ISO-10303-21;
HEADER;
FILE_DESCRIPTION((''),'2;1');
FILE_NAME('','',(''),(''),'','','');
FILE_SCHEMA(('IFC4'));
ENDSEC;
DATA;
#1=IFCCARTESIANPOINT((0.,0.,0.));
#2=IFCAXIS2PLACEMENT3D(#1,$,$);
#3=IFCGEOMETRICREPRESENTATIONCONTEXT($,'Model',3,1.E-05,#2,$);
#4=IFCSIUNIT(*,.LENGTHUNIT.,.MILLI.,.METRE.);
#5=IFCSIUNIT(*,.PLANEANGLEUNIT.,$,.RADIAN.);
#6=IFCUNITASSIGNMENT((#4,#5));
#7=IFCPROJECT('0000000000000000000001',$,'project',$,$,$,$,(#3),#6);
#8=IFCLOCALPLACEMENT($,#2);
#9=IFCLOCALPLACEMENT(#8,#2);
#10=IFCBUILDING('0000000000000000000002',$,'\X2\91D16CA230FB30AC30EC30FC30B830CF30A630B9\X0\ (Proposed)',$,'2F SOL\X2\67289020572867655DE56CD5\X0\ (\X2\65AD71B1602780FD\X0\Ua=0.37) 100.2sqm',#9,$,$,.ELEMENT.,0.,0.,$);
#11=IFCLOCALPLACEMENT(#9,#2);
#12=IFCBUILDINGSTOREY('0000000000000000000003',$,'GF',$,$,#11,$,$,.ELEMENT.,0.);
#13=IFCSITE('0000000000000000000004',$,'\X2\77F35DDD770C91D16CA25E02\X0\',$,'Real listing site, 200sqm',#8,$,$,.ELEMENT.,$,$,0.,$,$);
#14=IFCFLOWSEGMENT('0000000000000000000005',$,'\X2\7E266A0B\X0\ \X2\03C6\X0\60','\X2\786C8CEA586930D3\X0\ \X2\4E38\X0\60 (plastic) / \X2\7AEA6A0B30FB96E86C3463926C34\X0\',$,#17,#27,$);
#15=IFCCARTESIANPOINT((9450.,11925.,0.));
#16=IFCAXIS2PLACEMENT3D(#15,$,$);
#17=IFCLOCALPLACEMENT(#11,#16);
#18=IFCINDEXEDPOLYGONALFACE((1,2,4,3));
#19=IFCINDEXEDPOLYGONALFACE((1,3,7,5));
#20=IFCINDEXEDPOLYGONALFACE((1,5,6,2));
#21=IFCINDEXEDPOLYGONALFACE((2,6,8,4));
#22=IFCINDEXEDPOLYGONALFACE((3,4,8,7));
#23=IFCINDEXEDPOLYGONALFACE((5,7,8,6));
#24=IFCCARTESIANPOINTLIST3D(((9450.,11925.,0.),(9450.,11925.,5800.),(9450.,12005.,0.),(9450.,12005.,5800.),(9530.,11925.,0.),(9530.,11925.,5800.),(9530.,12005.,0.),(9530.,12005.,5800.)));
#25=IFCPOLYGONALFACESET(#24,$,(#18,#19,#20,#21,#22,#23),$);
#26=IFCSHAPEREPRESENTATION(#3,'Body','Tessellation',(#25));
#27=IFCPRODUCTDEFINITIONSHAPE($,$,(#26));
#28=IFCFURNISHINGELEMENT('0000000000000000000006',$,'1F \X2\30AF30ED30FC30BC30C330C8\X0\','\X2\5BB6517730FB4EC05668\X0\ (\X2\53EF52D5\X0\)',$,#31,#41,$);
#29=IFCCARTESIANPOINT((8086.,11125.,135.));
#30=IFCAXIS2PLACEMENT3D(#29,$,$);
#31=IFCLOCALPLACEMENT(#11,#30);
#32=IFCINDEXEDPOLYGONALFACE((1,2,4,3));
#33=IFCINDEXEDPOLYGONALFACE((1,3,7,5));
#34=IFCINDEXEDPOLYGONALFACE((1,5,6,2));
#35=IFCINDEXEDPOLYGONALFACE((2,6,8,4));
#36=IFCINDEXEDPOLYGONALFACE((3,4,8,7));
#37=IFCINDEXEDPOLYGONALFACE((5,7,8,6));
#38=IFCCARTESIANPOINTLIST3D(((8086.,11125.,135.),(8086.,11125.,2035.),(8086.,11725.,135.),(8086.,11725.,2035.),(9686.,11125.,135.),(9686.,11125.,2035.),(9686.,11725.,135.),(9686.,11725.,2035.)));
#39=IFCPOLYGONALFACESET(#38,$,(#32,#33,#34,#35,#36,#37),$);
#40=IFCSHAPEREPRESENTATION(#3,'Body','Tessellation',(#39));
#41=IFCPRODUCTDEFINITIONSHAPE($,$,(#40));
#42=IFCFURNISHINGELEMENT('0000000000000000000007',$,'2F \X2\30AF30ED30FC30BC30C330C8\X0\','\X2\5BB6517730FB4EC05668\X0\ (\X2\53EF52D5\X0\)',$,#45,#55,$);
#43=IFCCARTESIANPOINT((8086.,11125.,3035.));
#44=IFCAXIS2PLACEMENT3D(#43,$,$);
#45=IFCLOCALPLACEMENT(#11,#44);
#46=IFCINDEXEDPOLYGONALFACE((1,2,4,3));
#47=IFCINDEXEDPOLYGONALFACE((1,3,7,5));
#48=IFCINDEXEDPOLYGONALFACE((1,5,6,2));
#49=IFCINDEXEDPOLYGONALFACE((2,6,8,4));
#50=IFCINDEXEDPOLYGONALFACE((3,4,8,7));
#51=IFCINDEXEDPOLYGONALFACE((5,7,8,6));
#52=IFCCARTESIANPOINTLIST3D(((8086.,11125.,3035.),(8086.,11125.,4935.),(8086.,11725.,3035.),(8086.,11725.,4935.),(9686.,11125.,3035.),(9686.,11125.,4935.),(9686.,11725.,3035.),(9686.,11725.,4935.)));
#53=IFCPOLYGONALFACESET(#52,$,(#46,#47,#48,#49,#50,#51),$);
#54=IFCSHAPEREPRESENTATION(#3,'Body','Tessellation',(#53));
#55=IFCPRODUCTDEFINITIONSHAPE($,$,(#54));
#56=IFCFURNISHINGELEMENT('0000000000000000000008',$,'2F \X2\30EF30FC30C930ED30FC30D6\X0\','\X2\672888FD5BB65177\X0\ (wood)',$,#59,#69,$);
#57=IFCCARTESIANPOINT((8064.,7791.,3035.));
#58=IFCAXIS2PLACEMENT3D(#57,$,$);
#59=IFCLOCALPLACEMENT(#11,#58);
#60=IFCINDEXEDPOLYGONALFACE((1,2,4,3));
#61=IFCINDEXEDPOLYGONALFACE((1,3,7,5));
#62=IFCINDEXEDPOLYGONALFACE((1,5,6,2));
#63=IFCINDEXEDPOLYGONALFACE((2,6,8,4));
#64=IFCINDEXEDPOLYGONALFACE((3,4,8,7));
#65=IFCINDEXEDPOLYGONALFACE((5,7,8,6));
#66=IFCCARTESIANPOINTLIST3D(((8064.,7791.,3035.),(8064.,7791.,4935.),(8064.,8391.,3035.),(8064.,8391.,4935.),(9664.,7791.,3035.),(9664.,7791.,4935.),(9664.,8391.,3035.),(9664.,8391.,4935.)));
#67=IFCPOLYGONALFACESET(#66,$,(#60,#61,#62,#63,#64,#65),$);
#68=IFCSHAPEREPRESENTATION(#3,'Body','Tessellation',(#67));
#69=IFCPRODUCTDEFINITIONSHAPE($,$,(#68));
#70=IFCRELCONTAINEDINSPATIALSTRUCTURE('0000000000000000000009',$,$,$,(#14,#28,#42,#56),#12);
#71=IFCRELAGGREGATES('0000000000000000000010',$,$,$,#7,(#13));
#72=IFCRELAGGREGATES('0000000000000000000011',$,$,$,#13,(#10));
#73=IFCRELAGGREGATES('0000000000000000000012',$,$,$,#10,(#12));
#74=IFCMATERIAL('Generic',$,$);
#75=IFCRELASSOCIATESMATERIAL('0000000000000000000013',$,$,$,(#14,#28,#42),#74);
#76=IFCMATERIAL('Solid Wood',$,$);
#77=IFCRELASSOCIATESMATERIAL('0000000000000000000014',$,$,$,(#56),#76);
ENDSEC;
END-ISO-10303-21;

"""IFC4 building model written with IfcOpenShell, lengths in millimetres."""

from ifc_helpers import new_model, si_unit, frame, frame_2d, origin, place, context, project, spatial, rectangle, extrude, material, element, save


model = new_model("IFC4")

# Units and contexts
model_context = context("Model", 3, precision=1e-05, world=origin())
ifc_project = project(units=[si_unit("LENGTHUNIT", "METRE", prefix="MILLI"), si_unit("PLANEANGLEUNIT", "RADIAN")], contexts=[model_context])

# Site, building, storey
site_placement = place(None, origin())
site = spatial("IfcSite", under=ifc_project, at=site_placement, Name="石川県金沢市", ObjectType="Real listing site, 200sqm", CompositionType="ELEMENT", RefElevation=0.0)
building_placement = place(site_placement, origin())
building = spatial("IfcBuilding", under=site, at=building_placement, Name="金沢・ガレージハウス (Proposed)", ObjectType="2F SOL木造在来工法 (断熱性能Ua=0.37) 100.2sqm", CompositionType="ELEMENT", ElevationOfRefHeight=0.0, ElevationOfTerrain=0.0)
storey_placement = place(building_placement, origin())
storey = spatial("IfcBuildingStorey", under=building, at=storey_placement, Name="GF", CompositionType="ELEMENT", Elevation=0.0)

# Shared definitions
ifc_material_1 = material(Name="Solid Wood")

# Shared definitions
ifc_material_2 = material(Name="Generic")

# Flow segment
flow_segment_placement = place(storey_placement, frame((9450.0, 11925.0, 0.0)))
element("IfcFlowSegment", 1, at=flow_segment_placement, inside=storey, material=ifc_material_2, Name="縦樋 φ60", Description="硬質塩ビ 丸60 (plastic) / 竪樋・雨水排水", context=model_context, shape_type="SweptSolid", body=[
    extrude(rectangle(XDim=80.0, YDim=80.0, at=frame_2d((40.0, 40.0))), frame((9450.0, 11925.0, 0.0)), (0.0, 0.0, 1.0), 5800.0),
])

# Furnishing elements
furnishing_1_placement = place(storey_placement, frame((8086.0, 11125.0, 135.0)))
element("IfcFurnishingElement", 2, at=furnishing_1_placement, inside=storey, material=ifc_material_2, Name="1F クローゼット", Description="家具・什器 (可動)", context=model_context, shape_type="SweptSolid", body=[
    extrude(rectangle(XDim=1600.0, YDim=600.0, at=frame_2d((800.0, 300.0))), frame((8086.0, 11125.0, 135.0)), (0.0, 0.0, 1.0), 1900.0),
])
furnishing_2_placement = place(storey_placement, frame((8086.0, 11125.0, 3035.0)))
element("IfcFurnishingElement", 3, at=furnishing_2_placement, inside=storey, material=ifc_material_2, Name="2F クローゼット", Description="家具・什器 (可動)", context=model_context, shape_type="SweptSolid", body=[
    extrude(rectangle(XDim=1600.0, YDim=600.0, at=frame_2d((800.0, 300.0))), frame((8086.0, 11125.0, 3035.0)), (0.0, 0.0, 1.0), 1900.0),
])
furnishing_3_placement = place(storey_placement, frame((8064.0, 7791.0, 3035.0)))
element("IfcFurnishingElement", 4, at=furnishing_3_placement, inside=storey, material=ifc_material_1, Name="2F ワードローブ", Description="木製家具 (wood)", context=model_context, shape_type="SweptSolid", body=[
    extrude(rectangle(XDim=1600.0, YDim=600.0, at=frame_2d((800.0, 300.0))), frame((8064.0, 7791.0, 3035.0)), (0.0, 0.0, 1.0), 1900.0),
])

save(model, "model.ifc")
